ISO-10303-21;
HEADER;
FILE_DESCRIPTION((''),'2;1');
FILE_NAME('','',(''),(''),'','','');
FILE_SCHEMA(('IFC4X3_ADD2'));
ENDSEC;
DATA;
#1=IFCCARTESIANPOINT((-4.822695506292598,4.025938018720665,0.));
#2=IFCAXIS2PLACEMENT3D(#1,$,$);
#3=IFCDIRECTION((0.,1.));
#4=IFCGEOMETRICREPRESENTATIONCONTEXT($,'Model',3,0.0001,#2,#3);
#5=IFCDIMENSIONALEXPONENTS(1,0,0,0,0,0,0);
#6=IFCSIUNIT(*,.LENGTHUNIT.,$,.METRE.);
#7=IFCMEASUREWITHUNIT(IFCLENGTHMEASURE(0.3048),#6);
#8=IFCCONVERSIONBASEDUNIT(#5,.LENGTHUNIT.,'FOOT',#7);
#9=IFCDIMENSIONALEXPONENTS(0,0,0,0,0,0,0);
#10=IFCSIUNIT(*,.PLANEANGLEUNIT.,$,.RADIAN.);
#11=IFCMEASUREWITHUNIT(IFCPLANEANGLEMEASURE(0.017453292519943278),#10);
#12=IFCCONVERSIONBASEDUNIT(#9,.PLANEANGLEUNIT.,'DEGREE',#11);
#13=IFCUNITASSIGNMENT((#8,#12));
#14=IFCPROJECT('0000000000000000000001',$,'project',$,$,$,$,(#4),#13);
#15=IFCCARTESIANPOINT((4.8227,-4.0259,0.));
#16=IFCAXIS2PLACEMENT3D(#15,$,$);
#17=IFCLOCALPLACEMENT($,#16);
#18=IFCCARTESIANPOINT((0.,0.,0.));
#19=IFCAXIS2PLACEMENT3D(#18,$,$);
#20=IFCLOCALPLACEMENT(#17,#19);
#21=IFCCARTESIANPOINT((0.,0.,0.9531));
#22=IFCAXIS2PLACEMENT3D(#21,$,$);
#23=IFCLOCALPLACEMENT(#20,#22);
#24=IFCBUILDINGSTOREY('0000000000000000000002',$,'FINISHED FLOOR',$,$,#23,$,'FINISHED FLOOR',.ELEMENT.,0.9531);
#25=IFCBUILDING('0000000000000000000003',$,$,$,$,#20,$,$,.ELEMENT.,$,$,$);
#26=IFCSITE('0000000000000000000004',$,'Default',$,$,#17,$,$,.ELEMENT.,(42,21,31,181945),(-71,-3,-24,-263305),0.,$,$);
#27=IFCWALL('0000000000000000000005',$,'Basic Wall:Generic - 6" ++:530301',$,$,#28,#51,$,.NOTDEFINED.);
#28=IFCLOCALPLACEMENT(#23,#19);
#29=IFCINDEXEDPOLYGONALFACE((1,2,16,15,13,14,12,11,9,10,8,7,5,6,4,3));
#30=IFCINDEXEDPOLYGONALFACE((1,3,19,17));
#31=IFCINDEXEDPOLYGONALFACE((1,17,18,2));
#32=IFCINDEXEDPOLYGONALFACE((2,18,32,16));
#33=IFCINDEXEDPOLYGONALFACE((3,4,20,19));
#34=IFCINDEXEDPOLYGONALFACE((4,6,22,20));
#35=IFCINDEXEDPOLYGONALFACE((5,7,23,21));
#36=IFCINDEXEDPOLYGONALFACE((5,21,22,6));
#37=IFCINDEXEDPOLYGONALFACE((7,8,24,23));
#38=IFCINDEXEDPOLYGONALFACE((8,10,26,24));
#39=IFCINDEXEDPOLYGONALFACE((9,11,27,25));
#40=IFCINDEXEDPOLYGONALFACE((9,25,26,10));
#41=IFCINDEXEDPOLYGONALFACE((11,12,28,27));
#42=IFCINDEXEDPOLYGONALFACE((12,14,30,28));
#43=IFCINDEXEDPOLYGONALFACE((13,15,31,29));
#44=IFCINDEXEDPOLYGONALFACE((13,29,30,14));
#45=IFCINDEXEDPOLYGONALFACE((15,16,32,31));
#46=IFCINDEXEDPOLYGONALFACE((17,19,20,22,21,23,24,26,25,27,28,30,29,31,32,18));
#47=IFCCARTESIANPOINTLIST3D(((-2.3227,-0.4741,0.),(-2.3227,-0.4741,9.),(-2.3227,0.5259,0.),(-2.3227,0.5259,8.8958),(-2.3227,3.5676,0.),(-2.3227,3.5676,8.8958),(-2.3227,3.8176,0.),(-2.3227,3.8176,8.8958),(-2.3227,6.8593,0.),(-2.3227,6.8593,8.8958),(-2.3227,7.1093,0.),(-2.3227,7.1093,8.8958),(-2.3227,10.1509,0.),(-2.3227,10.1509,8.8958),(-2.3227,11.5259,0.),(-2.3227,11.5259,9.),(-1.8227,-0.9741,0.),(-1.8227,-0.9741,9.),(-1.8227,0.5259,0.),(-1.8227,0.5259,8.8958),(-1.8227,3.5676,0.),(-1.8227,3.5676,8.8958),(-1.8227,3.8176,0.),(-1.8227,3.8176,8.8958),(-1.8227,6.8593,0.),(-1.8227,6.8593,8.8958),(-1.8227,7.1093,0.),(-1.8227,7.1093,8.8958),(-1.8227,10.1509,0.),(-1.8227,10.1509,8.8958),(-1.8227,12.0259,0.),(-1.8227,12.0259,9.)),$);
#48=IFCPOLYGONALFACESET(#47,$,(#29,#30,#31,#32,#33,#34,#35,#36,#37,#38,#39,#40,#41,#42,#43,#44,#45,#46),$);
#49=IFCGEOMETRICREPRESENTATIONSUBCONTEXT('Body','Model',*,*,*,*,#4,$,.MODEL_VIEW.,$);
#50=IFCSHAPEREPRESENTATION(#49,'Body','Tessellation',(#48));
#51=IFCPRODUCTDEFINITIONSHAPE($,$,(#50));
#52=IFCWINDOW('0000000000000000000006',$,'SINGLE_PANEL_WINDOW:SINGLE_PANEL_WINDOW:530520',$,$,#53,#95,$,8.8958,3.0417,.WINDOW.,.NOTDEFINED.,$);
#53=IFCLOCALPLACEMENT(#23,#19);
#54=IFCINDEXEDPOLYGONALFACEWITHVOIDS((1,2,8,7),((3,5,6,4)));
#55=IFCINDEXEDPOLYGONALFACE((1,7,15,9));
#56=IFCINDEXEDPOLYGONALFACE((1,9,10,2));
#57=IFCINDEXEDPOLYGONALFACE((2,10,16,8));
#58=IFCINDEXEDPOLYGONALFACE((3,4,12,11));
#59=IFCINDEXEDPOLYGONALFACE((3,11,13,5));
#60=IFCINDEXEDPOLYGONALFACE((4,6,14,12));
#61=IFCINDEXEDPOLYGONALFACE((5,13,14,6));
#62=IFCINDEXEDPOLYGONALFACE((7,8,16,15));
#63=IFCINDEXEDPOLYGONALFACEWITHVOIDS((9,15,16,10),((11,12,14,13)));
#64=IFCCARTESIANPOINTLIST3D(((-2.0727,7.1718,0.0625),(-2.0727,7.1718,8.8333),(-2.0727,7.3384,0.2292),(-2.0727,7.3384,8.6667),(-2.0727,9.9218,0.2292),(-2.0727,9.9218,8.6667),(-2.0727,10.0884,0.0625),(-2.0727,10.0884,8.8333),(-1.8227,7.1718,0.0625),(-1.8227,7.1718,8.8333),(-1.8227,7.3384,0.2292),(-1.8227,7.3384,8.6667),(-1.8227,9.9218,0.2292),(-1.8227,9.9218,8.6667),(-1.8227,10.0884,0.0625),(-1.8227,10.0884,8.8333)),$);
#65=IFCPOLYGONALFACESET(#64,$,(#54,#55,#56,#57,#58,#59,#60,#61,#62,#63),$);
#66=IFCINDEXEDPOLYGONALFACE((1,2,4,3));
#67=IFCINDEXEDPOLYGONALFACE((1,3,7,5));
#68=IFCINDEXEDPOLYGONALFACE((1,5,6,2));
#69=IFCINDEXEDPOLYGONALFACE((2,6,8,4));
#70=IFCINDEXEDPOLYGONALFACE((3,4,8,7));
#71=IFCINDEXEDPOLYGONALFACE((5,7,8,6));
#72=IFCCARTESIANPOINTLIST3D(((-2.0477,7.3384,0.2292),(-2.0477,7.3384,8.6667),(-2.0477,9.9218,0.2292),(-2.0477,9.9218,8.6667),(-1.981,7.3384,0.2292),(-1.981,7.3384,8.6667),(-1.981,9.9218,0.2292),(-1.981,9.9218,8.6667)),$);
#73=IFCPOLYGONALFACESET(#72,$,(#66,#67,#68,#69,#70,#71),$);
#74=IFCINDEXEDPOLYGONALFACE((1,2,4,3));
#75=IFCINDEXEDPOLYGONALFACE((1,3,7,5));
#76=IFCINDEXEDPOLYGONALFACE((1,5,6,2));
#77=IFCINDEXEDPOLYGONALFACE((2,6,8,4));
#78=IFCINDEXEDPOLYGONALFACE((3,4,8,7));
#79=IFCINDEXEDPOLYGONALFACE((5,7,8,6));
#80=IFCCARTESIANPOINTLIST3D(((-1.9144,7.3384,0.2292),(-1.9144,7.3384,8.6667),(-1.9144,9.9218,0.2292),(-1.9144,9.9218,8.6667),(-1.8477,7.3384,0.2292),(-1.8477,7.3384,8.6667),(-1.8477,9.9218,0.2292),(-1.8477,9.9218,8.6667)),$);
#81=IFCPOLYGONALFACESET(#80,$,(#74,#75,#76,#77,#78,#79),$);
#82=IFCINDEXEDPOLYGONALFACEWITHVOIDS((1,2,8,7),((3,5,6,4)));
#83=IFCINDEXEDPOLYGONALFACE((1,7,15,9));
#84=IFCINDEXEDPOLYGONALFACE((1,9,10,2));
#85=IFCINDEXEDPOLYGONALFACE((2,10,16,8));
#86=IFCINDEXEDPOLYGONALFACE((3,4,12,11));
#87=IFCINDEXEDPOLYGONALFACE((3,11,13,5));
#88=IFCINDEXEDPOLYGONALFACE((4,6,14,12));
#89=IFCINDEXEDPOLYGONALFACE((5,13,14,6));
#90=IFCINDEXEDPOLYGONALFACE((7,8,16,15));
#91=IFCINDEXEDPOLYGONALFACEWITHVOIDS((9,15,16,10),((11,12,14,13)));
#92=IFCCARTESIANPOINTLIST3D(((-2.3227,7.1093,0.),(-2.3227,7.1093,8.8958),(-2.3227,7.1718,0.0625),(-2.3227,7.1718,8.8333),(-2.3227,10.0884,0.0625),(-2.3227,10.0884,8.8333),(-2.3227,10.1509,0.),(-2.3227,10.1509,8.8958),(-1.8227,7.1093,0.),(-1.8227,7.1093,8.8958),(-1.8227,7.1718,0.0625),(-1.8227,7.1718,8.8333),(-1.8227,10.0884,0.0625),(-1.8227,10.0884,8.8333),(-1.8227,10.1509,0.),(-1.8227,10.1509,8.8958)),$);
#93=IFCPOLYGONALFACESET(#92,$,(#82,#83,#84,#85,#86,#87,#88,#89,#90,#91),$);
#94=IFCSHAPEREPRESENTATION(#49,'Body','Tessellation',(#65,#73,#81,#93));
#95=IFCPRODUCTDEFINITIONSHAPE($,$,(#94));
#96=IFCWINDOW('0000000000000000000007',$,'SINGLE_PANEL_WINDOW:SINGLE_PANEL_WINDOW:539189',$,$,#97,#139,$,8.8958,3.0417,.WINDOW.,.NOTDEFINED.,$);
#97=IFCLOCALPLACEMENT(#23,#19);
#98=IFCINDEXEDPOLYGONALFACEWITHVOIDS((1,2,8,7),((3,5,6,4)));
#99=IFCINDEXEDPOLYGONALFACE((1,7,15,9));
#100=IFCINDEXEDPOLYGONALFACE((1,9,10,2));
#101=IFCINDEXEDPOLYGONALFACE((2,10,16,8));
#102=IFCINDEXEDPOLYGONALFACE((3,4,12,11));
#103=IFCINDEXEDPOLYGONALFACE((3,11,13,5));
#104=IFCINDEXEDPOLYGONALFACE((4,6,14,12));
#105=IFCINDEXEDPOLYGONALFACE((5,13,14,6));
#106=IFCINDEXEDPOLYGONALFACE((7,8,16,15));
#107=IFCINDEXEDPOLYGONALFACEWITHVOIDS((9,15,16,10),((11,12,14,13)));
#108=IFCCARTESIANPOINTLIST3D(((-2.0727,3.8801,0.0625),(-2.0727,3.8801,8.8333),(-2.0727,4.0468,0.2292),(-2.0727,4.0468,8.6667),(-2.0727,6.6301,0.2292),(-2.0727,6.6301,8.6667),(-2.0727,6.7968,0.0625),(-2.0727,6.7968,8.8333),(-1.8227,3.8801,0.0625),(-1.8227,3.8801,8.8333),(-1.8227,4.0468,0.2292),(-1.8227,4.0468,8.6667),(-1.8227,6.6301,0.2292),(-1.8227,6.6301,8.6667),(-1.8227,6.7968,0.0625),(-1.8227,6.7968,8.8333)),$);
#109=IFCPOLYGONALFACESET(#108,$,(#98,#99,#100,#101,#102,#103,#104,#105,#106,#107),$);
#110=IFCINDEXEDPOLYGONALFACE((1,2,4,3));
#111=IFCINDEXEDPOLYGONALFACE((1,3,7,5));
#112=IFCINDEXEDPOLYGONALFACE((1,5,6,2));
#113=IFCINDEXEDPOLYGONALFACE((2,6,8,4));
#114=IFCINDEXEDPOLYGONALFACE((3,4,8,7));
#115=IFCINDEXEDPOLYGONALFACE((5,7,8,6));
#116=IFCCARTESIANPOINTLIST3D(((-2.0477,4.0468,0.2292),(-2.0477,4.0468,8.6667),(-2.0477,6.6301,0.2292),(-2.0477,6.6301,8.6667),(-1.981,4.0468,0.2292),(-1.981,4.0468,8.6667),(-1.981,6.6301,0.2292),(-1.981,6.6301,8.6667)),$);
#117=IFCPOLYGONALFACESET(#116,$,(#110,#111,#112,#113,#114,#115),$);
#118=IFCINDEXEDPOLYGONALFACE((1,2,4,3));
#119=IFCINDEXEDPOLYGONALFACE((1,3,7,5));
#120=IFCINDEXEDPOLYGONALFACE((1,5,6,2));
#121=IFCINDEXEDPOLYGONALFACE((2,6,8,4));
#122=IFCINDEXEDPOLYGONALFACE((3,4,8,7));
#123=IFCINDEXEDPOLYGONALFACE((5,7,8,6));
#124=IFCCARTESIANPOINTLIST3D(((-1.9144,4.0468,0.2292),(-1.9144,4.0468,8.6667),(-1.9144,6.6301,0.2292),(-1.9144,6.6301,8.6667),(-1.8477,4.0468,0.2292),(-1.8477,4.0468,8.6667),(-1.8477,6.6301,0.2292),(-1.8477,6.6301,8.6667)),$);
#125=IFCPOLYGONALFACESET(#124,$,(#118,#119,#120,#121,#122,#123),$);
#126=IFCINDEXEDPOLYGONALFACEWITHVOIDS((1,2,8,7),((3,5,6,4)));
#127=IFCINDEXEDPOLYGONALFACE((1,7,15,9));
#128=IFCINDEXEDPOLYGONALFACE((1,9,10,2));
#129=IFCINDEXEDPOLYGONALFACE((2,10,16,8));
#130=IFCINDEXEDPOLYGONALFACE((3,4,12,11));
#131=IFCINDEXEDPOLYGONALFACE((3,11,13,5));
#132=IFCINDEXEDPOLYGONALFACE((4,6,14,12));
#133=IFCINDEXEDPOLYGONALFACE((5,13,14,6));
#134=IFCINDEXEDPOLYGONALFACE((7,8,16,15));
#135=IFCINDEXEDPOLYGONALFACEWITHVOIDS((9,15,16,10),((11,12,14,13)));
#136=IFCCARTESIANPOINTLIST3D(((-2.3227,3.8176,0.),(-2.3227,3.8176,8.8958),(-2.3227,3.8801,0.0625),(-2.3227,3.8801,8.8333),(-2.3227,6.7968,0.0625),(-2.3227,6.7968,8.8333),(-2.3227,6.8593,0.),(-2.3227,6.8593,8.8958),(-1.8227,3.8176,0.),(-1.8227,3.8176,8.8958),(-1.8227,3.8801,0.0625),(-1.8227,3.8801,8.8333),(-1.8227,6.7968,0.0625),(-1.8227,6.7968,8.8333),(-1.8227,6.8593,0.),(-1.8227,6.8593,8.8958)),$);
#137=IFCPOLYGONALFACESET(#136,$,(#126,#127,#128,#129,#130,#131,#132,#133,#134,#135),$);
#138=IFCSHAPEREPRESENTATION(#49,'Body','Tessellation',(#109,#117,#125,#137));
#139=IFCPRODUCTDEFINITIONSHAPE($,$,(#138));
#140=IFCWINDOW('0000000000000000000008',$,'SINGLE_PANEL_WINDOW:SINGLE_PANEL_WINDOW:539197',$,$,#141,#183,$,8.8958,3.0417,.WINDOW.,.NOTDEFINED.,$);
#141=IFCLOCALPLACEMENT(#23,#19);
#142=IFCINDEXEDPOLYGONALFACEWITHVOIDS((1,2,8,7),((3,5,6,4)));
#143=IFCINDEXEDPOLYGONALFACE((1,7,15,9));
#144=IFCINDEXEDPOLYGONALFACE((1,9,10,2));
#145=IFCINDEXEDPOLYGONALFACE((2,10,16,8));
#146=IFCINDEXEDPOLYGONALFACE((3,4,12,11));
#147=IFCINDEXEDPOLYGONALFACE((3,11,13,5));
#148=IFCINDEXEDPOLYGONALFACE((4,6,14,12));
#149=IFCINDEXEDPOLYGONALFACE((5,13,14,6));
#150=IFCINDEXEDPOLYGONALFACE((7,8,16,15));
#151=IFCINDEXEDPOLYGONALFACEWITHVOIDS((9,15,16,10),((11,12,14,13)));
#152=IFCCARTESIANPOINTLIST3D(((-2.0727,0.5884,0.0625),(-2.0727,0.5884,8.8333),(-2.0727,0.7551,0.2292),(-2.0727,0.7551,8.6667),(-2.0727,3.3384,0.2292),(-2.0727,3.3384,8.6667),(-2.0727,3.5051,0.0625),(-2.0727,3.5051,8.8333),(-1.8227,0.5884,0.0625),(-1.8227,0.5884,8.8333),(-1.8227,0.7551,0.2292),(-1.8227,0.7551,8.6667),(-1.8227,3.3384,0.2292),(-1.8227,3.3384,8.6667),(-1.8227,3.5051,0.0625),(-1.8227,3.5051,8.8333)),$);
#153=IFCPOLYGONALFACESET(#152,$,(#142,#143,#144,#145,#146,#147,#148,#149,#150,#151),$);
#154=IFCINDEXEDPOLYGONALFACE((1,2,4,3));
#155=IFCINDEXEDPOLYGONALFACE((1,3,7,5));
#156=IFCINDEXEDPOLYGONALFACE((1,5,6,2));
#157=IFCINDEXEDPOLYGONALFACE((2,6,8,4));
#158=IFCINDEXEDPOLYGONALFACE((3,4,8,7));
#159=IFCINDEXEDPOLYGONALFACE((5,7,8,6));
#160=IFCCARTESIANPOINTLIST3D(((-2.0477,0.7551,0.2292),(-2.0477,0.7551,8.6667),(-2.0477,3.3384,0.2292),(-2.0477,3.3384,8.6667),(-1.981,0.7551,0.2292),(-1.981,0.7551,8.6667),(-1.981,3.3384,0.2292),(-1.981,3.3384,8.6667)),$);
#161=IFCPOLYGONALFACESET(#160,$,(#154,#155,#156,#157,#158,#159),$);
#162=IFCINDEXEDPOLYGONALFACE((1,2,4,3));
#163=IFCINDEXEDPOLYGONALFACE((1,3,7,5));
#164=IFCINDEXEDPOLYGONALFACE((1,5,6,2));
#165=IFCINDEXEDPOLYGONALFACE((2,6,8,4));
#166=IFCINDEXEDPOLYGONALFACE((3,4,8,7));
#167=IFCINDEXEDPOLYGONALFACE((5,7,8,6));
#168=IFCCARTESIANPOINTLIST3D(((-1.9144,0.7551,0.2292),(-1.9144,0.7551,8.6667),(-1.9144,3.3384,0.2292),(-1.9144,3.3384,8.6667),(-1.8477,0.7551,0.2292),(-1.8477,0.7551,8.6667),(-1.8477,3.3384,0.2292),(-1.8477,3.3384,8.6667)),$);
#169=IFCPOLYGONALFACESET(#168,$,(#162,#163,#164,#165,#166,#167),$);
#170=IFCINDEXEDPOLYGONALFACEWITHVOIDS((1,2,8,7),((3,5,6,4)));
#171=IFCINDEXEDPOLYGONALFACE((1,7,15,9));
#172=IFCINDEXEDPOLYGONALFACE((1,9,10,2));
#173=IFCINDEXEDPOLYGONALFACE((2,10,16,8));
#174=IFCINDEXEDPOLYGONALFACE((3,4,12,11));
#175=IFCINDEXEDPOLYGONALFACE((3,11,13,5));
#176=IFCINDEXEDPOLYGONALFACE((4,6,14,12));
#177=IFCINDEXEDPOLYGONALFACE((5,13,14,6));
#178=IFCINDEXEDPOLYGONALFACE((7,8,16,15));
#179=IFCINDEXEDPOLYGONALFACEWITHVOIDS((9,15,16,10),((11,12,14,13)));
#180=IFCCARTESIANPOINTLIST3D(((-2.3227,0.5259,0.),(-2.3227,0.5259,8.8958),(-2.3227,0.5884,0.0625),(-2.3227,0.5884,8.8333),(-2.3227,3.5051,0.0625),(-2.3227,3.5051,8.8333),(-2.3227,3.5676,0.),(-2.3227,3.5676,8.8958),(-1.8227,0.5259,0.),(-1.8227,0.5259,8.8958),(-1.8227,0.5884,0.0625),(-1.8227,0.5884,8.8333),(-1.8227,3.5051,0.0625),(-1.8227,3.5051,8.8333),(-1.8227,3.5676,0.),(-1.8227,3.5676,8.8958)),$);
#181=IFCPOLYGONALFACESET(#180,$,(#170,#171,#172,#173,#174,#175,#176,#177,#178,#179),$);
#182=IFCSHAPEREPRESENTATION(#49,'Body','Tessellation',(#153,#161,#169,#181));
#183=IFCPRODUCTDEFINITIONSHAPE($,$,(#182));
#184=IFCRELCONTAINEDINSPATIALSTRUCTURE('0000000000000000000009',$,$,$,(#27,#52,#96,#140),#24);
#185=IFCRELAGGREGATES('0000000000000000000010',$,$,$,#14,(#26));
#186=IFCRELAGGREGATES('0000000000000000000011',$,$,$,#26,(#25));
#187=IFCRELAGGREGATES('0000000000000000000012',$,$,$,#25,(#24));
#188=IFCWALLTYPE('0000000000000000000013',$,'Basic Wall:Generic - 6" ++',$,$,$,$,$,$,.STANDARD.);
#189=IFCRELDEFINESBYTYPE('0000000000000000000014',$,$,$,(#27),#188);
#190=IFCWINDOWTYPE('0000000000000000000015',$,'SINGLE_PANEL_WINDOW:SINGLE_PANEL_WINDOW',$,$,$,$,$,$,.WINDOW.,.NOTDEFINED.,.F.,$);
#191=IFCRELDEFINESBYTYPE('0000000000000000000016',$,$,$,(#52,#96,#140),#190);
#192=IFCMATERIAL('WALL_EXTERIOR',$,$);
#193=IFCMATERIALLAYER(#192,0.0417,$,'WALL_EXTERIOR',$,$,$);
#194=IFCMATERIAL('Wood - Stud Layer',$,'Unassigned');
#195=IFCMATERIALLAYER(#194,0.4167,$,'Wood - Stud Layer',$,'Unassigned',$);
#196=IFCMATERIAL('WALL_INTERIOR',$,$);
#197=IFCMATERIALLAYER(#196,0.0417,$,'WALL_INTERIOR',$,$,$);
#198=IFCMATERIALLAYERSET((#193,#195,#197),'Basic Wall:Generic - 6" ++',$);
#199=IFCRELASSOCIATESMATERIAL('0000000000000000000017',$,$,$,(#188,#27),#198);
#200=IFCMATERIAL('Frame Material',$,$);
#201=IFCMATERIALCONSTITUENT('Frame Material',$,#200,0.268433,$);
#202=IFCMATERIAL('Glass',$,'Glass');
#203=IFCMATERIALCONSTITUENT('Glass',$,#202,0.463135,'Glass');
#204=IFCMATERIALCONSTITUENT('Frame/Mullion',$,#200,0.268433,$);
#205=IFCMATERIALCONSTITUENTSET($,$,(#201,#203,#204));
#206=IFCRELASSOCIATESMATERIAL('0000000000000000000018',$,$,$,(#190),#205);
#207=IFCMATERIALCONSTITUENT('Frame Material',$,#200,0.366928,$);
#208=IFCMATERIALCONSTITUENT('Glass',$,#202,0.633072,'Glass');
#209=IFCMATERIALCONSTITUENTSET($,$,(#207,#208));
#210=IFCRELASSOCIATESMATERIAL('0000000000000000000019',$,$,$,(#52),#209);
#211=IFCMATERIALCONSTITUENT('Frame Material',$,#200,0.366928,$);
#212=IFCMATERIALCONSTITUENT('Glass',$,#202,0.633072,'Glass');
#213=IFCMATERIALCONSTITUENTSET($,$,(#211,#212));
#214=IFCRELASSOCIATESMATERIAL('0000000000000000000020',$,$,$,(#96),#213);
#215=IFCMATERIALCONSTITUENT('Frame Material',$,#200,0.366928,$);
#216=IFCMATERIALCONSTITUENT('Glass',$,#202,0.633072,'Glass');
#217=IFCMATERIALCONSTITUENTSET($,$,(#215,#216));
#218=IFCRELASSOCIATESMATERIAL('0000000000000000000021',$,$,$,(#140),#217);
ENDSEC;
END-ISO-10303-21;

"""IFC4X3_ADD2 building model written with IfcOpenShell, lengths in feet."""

from ifc_helpers import new_model, entity, si_unit, converted_unit, direction, frame, frame_2d, origin, origin_2d_with_axis, place, context, subcontext, project, spatial, polyline, rectangle, outline, extrude, source, transform, mapped, material, layer, layer_set, constituent, constituent_set, type_object, type_shapes, element, fill, save


model = new_model("IFC4X3_ADD2")

# Units and contexts
model_context = context("Model", 3, precision=0.0001, world=frame((-4.822695506292598, 4.025938018720665, 0.0)), true_north=direction((0.0, 1.0)))
body_context = subcontext(model_context, "Body", "Model", "MODEL_VIEW")
ifc_project = project(units=[converted_unit("LENGTHUNIT", "FOOT", entity("IfcLengthMeasure", 0.3048), si_unit("LENGTHUNIT", "METRE"), dimensions=[1, 0, 0, 0, 0, 0, 0]), converted_unit("PLANEANGLEUNIT", "DEGREE", entity("IfcPlaneAngleMeasure", 0.017453292519943278), si_unit("PLANEANGLEUNIT", "RADIAN"), dimensions=[0, 0, 0, 0, 0, 0, 0])], contexts=[model_context])

# Site, building, storey
site_placement = place(None, frame((4.8227, -4.0259, 0.0)))
site = spatial("IfcSite", under=ifc_project, at=site_placement, Name="Default", CompositionType="ELEMENT", RefLatitude=(42, 21, 31, 181945), RefLongitude=(-71, -3, -24, -263305), RefElevation=0.0)
building_placement = place(site_placement, origin())
building = spatial("IfcBuilding", under=site, at=building_placement, CompositionType="ELEMENT")
storey_placement = place(building_placement, frame((0.0, 0.0, 0.9531)))
storey = spatial("IfcBuildingStorey", under=building, at=storey_placement, Name="FINISHED FLOOR", LongName="FINISHED FLOOR", CompositionType="ELEMENT", Elevation=0.9531)

# Shared definitions
ifc_material_1 = material(Name="WALL_EXTERIOR")
ifc_layer_1 = layer(ifc_material_1, 0.0417, Name="WALL_EXTERIOR")
ifc_material_2 = material(Name="Wood - Stud Layer", Category="Unassigned")
ifc_layer_2 = layer(ifc_material_2, 0.4167, Name="Wood - Stud Layer", Category="Unassigned")
ifc_material_3 = material(Name="WALL_INTERIOR")
ifc_layer_3 = layer(ifc_material_3, 0.0417, Name="WALL_INTERIOR")
ifc_layer_set_1 = layer_set([ifc_layer_1, ifc_layer_2, ifc_layer_3], Name="Basic Wall:Generic - 6\" ++")
wall_type_1 = type_object("IfcWallType", Name="Basic Wall:Generic - 6\" ++", PredefinedType="STANDARD", material=ifc_layer_set_1)
ifc_material_4 = material(Name="Frame Material")
ifc_material_5 = material(Name="Glass", Category="Glass")

# Wall, openings, windows
wall_1_placement = place(storey_placement, frame((-2.0727, 12.0259, 0.0), z_axis=(0.0, 0.0, 1.0), x_axis=(0.0, -1.0, 0.0)))
wall_1 = element("IfcWall", 1, at=wall_1_placement, inside=storey, type_object=wall_type_1, material=ifc_layer_set_1, Name="Basic Wall:Generic - 6\" ++:530301", PredefinedType="NOTDEFINED", context=body_context, shape_type="SweptSolid", body=[
    extrude(outline(polyline([(0.5, -0.25), (12.5, -0.25), (13.0, 0.25), (0.0, 0.25), (0.5, -0.25)])), origin(), (0.0, 0.0, 1.0), 9.0),
])
opening_1_placement = place(wall_1_placement, frame((1.875, -0.25, 0.0)))
opening_1 = element("IfcOpeningElement", 2, at=opening_1_placement, cuts=wall_1, PredefinedType="OPENING", context=body_context, shape_type="SweptSolid", body=[
    extrude(rectangle(XDim=8.8958, YDim=3.0417, at=frame_2d((4.4479, 1.5208), x_axis=(-1.0, 0.0))), frame((0.0, 0.0, 0.0), z_axis=(0.0, 1.0, 0.0), x_axis=(0.0, 0.0, 1.0)), (0.0, 0.0, 1.0), 0.5),
])
opening_2_placement = place(wall_1_placement, frame((5.1667, -0.25, 0.0)))
opening_2 = element("IfcOpeningElement", 3, at=opening_2_placement, cuts=wall_1, PredefinedType="OPENING", context=body_context, shape_type="SweptSolid", body=[
    extrude(rectangle(XDim=8.8958, YDim=3.0417, at=frame_2d((4.4479, 1.5208), x_axis=(-1.0, 0.0))), frame((0.0, 0.0, 0.0), z_axis=(0.0, 1.0, 0.0), x_axis=(0.0, 0.0, 1.0)), (0.0, 0.0, 1.0), 0.5),
])
opening_3_placement = place(wall_1_placement, frame((8.4583, -0.25, 0.0)))
opening_3 = element("IfcOpeningElement", 4, at=opening_3_placement, cuts=wall_1, PredefinedType="OPENING", context=body_context, shape_type="SweptSolid", body=[
    extrude(rectangle(XDim=8.8958, YDim=3.0417, at=frame_2d((4.4479, 1.5208), x_axis=(-1.0, 0.0))), frame((0.0, 0.0, 0.0), z_axis=(0.0, 1.0, 0.0), x_axis=(0.0, 0.0, 1.0)), (0.0, 0.0, 1.0), 0.5),
])
ifc_constituent_1 = constituent(ifc_material_4, Name="Frame Material", fraction=0.366928)
ifc_constituent_2 = constituent(ifc_material_5, Name="Glass", Category="Glass", fraction=0.633072)
ifc_constituent_set_1 = constituent_set(constituents=[ifc_constituent_1, ifc_constituent_2])
ifc_constituent_3 = constituent(ifc_material_4, Name="Frame Material", fraction=0.268433)
ifc_constituent_4 = constituent(ifc_material_5, Name="Glass", Category="Glass", fraction=0.463135)
ifc_constituent_5 = constituent(ifc_material_4, Name="Frame/Mullion", fraction=0.268433)
ifc_constituent_set_2 = constituent_set(constituents=[ifc_constituent_3, ifc_constituent_4, ifc_constituent_5])
window_type_1 = type_object("IfcWindowType", Name="SINGLE_PANEL_WINDOW:SINGLE_PANEL_WINDOW", ParameterTakesPrecedence=False, PartitioningType="NOTDEFINED", PredefinedType="WINDOW", material=ifc_constituent_set_2)
shared_shape_1 = source(origin(), body_context, "Body", "SweptSolid", [
    extrude(outline(polyline([(-1.4583, -4.3854), (1.4583, -4.3854), (1.4583, 4.3854), (-1.4583, 4.3854), (-1.4583, -4.3854)]), holes=[polyline([(1.2917, 4.2187), (1.2917, -4.2188), (-1.2917, -4.2188), (-1.2917, 4.2187), (1.2917, 4.2187)])]), frame((1.5208, 0.5, 4.4479), z_axis=(0.0, -1.0, 0.0), x_axis=(-1.0, 0.0, 0.0)), (0.0, 0.0, 1.0), 0.25),
    extrude(rectangle(XDim=2.5833, YDim=0.0667, at=origin_2d_with_axis()), frame((1.5208, 0.3083, 0.2292), z_axis=(0.0, 0.0, 1.0), x_axis=(-1.0, 0.0, 0.0)), (0.0, 0.0, 1.0), 8.4375),
    extrude(rectangle(XDim=2.5833, YDim=0.0667, at=frame_2d((0.0, 0.0), x_axis=(1.0, 0.0))), frame((1.5208, 0.4417, 0.2292), z_axis=(0.0, 0.0, 1.0), x_axis=(-1.0, 0.0, 0.0)), (0.0, 0.0, 1.0), 8.4375),
    extrude(outline(polyline([(-4.4479, -1.5208), (4.4479, -1.5208), (4.4479, 1.5208), (-4.4479, 1.5208), (-4.4479, -1.5208)]), holes=[polyline([(-4.3854, -1.4583), (-4.3854, 1.4583), (4.3854, 1.4583), (4.3854, -1.4583), (-4.3854, -1.4583)])]), frame((1.5208, 0.5, 4.4479), z_axis=(0.0, -1.0, 0.0), x_axis=(0.0, 0.0, -1.0)), (0.0, 0.0, 1.0), 0.5),
])
type_shapes(window_type_1, [shared_shape_1])
window_1_placement = place(opening_1_placement, origin())
window_1 = element("IfcWindow", 5, at=window_1_placement, inside=storey, type_object=window_type_1, material=ifc_constituent_set_1, Name="SINGLE_PANEL_WINDOW:SINGLE_PANEL_WINDOW:530520", OverallHeight=8.8958, OverallWidth=3.0417, PartitioningType="NOTDEFINED", PredefinedType="WINDOW", context=body_context, shape_type="MappedRepresentation", body=[
    mapped(shared_shape_1, transform((0.0, 0.0, 0.0), scale=1.0)),
])
fill(opening_1, window_1)
ifc_constituent_6 = constituent(ifc_material_4, Name="Frame Material", fraction=0.366928)
ifc_constituent_7 = constituent(ifc_material_5, Name="Glass", Category="Glass", fraction=0.633072)
ifc_constituent_set_3 = constituent_set(constituents=[ifc_constituent_6, ifc_constituent_7])
window_2_placement = place(opening_2_placement, origin())
window_2 = element("IfcWindow", 6, at=window_2_placement, inside=storey, type_object=window_type_1, material=ifc_constituent_set_3, Name="SINGLE_PANEL_WINDOW:SINGLE_PANEL_WINDOW:539189", OverallHeight=8.8958, OverallWidth=3.0417, PartitioningType="NOTDEFINED", PredefinedType="WINDOW", context=body_context, shape_type="MappedRepresentation", body=[
    mapped(shared_shape_1, transform((0.0, 0.0, 0.0), scale=1.0)),
])
fill(opening_2, window_2)
ifc_constituent_8 = constituent(ifc_material_4, Name="Frame Material", fraction=0.366928)
ifc_constituent_9 = constituent(ifc_material_5, Name="Glass", Category="Glass", fraction=0.633072)
ifc_constituent_set_4 = constituent_set(constituents=[ifc_constituent_8, ifc_constituent_9])
window_3_placement = place(opening_3_placement, origin())
window_3 = element("IfcWindow", 7, at=window_3_placement, inside=storey, type_object=window_type_1, material=ifc_constituent_set_4, Name="SINGLE_PANEL_WINDOW:SINGLE_PANEL_WINDOW:539197", OverallHeight=8.8958, OverallWidth=3.0417, PartitioningType="NOTDEFINED", PredefinedType="WINDOW", context=body_context, shape_type="MappedRepresentation", body=[
    mapped(shared_shape_1, transform((0.0, 0.0, 0.0), scale=1.0)),
])
fill(opening_3, window_3)

save(model, "model.ifc")
